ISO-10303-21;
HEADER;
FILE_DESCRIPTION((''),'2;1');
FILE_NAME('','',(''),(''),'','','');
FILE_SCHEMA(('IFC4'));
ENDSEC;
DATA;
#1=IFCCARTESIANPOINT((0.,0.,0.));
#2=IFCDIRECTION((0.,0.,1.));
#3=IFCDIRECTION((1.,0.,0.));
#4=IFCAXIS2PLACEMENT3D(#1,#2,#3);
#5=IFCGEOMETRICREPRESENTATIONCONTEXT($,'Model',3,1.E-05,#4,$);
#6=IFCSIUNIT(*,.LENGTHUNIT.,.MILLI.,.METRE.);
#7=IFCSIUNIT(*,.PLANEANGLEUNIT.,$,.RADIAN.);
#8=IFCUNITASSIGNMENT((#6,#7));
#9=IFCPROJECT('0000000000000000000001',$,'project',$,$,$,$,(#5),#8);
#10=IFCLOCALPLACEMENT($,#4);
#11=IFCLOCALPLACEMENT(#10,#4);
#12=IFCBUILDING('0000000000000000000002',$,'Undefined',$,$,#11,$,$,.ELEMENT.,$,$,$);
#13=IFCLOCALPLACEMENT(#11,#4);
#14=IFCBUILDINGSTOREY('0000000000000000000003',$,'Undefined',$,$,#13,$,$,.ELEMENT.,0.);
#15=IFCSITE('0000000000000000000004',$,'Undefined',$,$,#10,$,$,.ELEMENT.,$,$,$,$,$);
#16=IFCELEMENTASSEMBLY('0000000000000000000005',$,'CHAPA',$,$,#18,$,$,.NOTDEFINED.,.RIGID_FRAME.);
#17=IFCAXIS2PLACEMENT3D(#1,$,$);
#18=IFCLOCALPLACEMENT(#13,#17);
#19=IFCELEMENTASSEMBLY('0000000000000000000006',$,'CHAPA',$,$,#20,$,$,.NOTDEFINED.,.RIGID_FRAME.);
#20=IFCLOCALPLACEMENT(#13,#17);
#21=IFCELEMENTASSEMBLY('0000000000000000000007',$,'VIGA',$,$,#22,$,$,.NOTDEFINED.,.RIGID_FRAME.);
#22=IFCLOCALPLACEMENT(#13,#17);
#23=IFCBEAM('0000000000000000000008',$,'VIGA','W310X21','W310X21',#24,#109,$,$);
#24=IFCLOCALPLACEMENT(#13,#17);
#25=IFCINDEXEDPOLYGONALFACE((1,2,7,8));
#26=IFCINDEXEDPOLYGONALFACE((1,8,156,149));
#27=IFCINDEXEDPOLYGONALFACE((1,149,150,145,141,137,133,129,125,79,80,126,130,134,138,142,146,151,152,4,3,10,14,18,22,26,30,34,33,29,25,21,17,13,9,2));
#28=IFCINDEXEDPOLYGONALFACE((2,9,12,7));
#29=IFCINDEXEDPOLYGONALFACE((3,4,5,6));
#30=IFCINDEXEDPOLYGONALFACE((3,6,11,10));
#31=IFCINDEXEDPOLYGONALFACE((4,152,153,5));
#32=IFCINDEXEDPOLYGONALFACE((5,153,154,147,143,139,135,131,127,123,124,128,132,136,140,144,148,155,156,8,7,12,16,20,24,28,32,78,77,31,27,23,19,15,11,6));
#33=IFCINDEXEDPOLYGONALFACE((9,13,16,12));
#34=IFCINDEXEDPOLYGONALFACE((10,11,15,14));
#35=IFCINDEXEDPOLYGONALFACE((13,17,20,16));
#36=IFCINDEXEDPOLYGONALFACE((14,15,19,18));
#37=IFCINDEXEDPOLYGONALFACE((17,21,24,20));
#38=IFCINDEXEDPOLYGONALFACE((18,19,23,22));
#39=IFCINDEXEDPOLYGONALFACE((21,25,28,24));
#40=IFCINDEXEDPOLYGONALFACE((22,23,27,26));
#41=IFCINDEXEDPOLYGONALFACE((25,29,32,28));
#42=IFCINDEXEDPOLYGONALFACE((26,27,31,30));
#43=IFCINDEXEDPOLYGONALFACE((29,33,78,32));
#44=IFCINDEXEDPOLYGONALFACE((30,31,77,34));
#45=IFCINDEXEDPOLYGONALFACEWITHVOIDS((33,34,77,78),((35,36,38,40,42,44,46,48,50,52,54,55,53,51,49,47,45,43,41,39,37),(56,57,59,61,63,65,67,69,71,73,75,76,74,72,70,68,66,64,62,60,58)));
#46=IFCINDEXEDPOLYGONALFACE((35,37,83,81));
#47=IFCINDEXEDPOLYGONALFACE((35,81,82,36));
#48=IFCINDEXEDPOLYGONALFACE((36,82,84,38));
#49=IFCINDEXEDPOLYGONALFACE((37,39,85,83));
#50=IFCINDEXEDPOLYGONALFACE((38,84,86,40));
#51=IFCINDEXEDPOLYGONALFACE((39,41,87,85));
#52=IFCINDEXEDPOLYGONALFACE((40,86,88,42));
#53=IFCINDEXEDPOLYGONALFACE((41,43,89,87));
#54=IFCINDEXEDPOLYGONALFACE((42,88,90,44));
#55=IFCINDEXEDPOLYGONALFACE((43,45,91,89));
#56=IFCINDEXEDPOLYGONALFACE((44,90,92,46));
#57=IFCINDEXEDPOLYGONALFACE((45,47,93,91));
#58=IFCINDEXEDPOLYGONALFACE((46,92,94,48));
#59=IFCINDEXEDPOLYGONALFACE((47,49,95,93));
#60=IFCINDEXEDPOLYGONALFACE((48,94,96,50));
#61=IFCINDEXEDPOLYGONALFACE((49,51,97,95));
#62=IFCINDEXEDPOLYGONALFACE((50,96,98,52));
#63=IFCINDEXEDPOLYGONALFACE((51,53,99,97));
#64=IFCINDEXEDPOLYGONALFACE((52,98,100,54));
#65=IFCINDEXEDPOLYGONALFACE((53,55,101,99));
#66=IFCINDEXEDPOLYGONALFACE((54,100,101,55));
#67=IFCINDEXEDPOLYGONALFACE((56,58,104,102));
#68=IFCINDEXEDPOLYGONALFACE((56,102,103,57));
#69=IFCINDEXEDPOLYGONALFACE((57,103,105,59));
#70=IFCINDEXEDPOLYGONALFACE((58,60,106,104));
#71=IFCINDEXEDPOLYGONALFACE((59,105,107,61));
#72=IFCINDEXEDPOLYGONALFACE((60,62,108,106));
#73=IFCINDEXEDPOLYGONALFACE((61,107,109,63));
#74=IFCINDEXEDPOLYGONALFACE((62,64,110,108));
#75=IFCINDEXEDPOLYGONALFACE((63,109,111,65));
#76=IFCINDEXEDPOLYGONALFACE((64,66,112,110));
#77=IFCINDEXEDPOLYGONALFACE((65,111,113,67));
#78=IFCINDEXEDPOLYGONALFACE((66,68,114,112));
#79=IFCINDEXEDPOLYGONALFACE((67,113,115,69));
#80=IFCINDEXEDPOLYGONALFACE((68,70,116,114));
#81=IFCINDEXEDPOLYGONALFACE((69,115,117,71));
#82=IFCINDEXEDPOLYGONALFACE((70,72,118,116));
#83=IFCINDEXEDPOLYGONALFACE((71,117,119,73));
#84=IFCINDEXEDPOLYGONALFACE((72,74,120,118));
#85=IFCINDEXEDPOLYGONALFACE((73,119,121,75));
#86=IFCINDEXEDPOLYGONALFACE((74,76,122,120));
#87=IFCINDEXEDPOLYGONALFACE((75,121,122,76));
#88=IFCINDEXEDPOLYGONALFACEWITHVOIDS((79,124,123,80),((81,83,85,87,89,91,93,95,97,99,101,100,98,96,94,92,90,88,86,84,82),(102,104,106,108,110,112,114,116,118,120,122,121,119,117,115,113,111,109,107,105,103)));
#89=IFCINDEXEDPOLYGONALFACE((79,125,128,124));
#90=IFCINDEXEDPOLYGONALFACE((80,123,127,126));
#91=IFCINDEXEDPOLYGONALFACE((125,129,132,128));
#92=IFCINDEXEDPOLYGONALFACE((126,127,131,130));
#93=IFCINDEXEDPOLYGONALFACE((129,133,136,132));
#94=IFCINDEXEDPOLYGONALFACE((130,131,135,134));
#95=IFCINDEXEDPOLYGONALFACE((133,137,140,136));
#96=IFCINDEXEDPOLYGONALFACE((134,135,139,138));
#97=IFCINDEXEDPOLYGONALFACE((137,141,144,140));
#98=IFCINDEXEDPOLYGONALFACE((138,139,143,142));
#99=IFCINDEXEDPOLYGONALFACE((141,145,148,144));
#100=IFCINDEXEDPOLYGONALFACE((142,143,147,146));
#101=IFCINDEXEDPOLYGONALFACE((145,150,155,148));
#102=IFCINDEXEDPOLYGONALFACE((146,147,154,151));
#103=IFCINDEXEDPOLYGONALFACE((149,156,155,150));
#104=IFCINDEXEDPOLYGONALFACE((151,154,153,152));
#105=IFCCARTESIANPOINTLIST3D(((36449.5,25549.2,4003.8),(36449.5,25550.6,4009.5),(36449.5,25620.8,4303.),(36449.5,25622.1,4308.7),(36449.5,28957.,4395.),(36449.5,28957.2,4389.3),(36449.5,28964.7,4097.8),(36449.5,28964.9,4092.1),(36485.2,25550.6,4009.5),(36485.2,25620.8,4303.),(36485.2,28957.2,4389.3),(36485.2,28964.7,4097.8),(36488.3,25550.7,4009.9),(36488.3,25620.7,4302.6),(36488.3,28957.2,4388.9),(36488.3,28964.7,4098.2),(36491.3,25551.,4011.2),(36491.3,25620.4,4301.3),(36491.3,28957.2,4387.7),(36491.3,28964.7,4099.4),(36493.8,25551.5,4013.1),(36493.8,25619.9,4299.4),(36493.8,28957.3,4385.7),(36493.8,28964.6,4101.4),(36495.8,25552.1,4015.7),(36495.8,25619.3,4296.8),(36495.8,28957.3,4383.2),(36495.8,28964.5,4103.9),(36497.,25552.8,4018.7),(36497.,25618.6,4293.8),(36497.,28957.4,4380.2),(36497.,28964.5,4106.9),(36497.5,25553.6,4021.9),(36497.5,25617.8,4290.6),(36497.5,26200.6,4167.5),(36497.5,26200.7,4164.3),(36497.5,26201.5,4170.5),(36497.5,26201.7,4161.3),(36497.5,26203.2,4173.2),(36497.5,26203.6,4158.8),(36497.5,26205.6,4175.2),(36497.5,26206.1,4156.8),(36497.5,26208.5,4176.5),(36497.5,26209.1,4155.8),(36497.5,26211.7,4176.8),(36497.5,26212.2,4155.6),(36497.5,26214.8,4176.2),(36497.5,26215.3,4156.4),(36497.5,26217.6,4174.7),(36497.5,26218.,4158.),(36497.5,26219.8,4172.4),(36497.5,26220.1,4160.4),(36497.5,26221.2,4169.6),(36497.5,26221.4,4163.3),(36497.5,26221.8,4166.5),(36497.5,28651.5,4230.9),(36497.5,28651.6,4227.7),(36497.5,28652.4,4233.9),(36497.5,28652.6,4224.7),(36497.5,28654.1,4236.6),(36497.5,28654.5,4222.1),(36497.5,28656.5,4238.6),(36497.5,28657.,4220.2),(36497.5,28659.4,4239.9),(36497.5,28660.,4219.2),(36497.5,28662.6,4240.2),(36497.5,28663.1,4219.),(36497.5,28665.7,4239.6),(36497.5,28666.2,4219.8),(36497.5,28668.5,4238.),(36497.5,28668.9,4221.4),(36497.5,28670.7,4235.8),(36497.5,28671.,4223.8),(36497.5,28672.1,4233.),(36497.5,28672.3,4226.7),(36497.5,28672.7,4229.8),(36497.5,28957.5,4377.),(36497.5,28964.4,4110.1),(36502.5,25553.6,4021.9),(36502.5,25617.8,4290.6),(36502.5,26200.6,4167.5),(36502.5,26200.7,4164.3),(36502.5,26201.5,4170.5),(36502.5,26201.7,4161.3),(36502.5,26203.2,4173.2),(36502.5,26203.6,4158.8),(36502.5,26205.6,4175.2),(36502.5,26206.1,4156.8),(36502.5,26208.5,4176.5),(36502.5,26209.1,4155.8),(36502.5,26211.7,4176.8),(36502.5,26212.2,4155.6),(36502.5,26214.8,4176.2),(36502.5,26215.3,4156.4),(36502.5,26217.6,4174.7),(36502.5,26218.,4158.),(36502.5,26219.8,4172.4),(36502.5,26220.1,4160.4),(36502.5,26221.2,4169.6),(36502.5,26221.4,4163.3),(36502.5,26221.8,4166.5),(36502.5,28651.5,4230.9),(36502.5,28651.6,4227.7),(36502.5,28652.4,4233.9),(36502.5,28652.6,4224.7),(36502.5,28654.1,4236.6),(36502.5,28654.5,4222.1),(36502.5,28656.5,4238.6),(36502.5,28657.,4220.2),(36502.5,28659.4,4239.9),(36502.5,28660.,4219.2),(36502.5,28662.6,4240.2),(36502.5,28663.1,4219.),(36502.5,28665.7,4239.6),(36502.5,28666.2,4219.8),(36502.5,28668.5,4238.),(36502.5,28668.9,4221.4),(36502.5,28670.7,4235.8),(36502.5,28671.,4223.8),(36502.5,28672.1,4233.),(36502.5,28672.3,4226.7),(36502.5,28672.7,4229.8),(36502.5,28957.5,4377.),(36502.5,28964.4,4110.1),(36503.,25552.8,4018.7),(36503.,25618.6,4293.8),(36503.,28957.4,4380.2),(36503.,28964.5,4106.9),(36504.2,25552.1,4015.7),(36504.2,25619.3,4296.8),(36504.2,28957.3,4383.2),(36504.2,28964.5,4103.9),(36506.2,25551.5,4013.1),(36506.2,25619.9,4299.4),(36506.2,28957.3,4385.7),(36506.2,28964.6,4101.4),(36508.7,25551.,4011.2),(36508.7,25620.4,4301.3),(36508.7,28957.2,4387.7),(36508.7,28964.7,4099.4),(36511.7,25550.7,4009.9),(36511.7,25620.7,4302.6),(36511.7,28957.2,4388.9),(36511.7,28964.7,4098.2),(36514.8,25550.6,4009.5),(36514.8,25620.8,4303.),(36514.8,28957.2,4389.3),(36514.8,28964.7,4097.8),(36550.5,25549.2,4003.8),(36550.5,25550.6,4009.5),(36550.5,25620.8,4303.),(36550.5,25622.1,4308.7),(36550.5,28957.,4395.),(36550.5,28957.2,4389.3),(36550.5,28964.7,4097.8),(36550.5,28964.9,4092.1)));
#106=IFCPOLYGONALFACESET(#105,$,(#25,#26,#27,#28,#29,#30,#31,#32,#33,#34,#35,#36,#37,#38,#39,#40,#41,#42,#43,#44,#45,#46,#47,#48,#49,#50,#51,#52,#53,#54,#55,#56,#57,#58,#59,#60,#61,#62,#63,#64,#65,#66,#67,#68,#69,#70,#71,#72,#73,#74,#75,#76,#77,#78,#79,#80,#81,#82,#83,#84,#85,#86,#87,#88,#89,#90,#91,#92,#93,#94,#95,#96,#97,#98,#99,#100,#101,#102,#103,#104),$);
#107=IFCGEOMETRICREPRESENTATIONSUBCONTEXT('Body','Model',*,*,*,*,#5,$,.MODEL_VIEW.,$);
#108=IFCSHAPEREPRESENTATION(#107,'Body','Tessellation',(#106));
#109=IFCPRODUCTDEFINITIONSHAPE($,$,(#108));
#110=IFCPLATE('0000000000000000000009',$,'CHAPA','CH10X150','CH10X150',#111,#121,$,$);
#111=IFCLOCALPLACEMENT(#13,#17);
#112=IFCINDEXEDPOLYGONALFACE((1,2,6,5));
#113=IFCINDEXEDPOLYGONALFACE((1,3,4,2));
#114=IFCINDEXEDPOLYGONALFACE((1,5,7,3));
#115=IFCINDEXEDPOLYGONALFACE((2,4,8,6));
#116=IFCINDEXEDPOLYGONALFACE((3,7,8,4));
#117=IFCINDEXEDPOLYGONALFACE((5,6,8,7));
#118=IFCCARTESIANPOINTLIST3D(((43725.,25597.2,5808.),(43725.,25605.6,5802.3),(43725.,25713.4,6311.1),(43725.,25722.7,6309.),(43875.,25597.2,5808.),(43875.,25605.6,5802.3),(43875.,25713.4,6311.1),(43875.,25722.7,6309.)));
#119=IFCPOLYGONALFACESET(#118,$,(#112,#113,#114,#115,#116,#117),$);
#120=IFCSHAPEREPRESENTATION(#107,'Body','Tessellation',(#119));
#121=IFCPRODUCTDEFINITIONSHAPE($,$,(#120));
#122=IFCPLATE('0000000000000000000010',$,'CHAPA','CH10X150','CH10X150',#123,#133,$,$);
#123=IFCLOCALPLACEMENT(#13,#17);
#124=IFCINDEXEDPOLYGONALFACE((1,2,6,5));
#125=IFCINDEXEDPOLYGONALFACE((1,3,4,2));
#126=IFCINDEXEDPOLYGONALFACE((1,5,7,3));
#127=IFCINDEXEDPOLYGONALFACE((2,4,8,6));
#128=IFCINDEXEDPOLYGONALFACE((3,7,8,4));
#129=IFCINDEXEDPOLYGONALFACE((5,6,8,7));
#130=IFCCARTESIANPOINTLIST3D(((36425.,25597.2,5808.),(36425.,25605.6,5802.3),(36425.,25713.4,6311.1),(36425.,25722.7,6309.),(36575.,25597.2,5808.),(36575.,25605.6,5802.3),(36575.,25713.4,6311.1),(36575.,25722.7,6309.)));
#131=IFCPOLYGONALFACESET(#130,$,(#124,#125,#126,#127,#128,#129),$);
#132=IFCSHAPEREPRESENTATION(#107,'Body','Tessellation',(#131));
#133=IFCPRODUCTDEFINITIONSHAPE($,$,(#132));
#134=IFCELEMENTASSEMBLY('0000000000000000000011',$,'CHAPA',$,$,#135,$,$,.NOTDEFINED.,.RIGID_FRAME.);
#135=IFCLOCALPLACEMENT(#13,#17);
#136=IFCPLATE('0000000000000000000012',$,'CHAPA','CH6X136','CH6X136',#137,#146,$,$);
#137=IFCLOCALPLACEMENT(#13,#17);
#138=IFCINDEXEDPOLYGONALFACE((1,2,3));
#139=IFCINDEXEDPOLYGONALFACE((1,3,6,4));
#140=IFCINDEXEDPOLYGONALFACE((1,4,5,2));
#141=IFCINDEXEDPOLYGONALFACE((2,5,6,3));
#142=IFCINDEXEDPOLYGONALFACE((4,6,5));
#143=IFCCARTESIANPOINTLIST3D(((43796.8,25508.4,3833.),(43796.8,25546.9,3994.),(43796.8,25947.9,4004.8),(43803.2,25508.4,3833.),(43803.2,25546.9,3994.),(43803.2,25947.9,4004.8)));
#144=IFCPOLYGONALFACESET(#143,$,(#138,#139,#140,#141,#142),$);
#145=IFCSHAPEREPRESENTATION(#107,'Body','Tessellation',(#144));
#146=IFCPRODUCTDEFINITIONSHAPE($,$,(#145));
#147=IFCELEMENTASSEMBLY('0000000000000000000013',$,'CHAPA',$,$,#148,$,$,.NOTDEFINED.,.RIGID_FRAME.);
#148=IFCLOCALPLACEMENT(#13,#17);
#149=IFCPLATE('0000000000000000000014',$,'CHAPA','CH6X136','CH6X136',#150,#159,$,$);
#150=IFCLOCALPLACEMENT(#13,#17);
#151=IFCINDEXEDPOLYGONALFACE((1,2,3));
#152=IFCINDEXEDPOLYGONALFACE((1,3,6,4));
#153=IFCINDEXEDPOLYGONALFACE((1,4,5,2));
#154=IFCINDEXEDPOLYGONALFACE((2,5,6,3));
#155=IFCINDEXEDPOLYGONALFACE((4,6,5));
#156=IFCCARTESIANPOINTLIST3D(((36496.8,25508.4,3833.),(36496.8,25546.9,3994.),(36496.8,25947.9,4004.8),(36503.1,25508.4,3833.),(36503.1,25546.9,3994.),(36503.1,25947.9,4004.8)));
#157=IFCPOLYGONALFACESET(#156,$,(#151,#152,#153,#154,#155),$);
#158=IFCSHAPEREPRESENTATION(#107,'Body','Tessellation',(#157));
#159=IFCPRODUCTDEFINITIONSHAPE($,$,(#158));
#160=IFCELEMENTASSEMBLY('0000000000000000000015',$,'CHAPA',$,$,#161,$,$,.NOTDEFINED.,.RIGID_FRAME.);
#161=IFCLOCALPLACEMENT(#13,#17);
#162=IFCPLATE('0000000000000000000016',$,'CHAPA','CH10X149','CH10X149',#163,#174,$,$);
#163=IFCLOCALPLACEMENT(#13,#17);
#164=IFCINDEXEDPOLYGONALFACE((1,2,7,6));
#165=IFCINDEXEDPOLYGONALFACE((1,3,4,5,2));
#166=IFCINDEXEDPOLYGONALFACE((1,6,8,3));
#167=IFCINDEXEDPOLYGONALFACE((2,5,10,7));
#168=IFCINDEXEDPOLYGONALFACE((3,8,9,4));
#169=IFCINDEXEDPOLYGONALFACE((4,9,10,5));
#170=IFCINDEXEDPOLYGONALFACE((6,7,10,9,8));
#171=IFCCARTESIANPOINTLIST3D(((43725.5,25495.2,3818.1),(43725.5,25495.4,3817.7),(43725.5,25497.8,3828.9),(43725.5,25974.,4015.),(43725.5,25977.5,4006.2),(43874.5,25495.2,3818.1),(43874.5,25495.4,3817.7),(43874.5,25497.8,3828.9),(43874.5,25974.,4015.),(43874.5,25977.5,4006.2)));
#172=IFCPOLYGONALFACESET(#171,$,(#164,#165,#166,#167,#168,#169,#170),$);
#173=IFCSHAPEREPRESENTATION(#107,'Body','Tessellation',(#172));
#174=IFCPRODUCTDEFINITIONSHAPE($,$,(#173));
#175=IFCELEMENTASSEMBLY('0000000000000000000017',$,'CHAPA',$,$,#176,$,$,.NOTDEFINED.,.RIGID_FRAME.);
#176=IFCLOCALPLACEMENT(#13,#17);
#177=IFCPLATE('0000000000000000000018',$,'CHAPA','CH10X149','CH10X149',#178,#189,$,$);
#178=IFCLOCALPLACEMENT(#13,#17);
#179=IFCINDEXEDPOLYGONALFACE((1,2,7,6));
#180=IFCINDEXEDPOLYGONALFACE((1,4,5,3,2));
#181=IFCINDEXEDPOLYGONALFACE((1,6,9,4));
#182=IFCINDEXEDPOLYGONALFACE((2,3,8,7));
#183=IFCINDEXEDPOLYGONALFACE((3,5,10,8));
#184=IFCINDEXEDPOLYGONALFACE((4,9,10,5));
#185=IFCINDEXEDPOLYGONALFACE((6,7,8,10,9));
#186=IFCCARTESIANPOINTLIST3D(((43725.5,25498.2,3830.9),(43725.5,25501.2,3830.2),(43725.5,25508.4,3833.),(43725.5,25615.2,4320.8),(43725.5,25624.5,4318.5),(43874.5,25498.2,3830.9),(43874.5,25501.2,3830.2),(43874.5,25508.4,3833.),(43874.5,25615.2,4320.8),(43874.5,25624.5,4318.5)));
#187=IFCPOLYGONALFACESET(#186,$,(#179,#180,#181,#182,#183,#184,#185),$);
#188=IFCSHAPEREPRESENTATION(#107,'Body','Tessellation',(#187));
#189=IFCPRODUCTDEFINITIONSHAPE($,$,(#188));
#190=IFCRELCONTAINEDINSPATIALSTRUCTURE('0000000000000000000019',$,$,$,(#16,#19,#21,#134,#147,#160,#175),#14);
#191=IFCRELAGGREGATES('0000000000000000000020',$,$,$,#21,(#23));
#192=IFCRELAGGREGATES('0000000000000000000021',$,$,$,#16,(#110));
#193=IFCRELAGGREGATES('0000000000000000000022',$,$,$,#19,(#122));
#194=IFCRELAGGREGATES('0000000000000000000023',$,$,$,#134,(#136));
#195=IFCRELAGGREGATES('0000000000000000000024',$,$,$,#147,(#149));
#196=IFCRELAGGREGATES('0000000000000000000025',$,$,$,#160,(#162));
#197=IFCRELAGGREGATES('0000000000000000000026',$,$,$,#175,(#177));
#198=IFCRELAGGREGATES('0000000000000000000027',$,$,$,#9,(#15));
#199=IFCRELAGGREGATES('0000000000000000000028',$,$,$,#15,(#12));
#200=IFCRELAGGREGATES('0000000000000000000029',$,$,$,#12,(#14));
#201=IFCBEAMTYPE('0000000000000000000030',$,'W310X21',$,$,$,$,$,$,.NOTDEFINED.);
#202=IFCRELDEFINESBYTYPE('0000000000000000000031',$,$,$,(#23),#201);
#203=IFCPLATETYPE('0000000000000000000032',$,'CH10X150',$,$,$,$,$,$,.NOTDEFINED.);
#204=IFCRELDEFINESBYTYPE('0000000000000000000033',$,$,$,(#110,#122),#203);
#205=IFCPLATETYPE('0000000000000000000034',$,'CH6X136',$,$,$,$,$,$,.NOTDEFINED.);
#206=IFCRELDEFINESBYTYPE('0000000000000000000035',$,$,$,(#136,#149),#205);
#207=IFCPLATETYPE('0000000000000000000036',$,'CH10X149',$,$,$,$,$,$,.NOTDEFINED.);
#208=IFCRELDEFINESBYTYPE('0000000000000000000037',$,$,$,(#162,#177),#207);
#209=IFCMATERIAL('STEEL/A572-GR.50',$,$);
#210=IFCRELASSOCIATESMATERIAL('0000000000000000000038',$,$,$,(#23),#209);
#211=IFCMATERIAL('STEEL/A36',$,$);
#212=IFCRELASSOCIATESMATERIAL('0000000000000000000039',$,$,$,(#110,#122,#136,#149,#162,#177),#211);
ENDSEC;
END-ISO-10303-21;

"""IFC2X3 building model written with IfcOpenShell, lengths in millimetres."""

from ifc_helpers import new_model, si_unit, frame, origin_with_axes, origin_2d_with_axis, place, context, subcontext, project, spatial, polyline, circle, i_section, outline, extrude, boolean, clip, halfspace, material, type_object, element, aggregate, save


model = new_model("IFC2X3")

# Units and contexts
model_context = context("Model", 3, precision=1e-05, world=origin_with_axes())
body_context = subcontext(model_context, "Body", "Model", "MODEL_VIEW")
ifc_project = project(units=[si_unit("LENGTHUNIT", "METRE", prefix="MILLI"), si_unit("PLANEANGLEUNIT", "RADIAN")], contexts=[model_context])

# Site, building, storey
site_placement = place(None, origin_with_axes())
site = spatial("IfcSite", under=ifc_project, at=site_placement, Name="Undefined", CompositionType="ELEMENT")
building_placement = place(site_placement, origin_with_axes())
building = spatial("IfcBuilding", under=site, at=building_placement, Name="Undefined", CompositionType="ELEMENT")
storey_placement = place(building_placement, origin_with_axes())
storey = spatial("IfcBuildingStorey", under=building, at=storey_placement, Name="Undefined", CompositionType="ELEMENT", Elevation=0.0)

# Element assemblies, beam
ifc_material_1 = material(Name="STEEL/A572-GR.50")
assembly_1_placement = place(storey_placement, origin_with_axes())
assembly_1 = element("IfcElementAssembly", 1, at=assembly_1_placement, inside=storey, Name="CHAPA", AssemblyPlace="NOTDEFINED", PredefinedType="RIGID_FRAME")
assembly_2_placement = place(storey_placement, origin_with_axes())
assembly_2 = element("IfcElementAssembly", 2, at=assembly_2_placement, inside=storey, Name="CHAPA", AssemblyPlace="NOTDEFINED", PredefinedType="RIGID_FRAME")
beam_type_1 = type_object("IfcBeamType", Name="W310X21", PredefinedType="NOTDEFINED")
assembly_3_placement = place(storey_placement, origin_with_axes())
assembly_3 = element("IfcElementAssembly", 3, at=assembly_3_placement, inside=storey, Name="VIGA", AssemblyPlace="NOTDEFINED", PredefinedType="RIGID_FRAME")
beam_1_placement = place(assembly_3_placement, frame((36500.0, 25403.9, 4151.6), z_axis=(0.0, -0.025855, 0.999666), x_axis=(0.0, 0.999666, 0.025855)))
beam_1 = element("IfcBeam", 4, at=beam_1_placement, type_object=beam_type_1, material=ifc_material_1, Name="VIGA", Description="W310X21", ObjectType="W310X21", context=body_context, shape_type="CSG", body=[
    boolean("DIFFERENCE", boolean("DIFFERENCE", boolean("DIFFERENCE", extrude(i_section(OverallWidth=101.0, OverallDepth=303.0, WebThickness=5.1, FlangeThickness=5.7, FilletRadius=12.3, at=origin_2d_with_axis()), frame((3558.2, 0.0, 0.0), z_axis=(-1.0, 0.0, 0.0), x_axis=(0.0, -1.0, 0.0)), (0.0, 0.0, 1.0), 3558.2), extrude(circle(Radius=10.6, at=origin_2d_with_axis()), frame((3259.1, -100.0, -6.3), z_axis=(0.0, 1.0, 0.0), x_axis=(1.0, 0.0, 0.0)), (0.0, 0.0, 1.0), 200.0)), extrude(circle(Radius=10.6, at=origin_2d_with_axis()), frame((807.4, -100.0, -6.2), z_axis=(0.0, 1.0, 0.0), x_axis=(1.0, 0.0, 0.0)), (0.0, 0.0, 1.0), 200.0)), halfspace(frame((141.4, -50.5, -151.7), z_axis=(-0.966259, 0.0, 0.257573), x_axis=(0.0, 1.0, 0.0)), False)),
])
aggregate(assembly_3, [beam_1])

# Plates
ifc_material_2 = material(Name="STEEL/A36")
plate_type_1 = type_object("IfcPlateType", Name="CH10X150", PredefinedType="NOTDEFINED")
plate_1_placement = place(assembly_1_placement, frame((43875.0, 25718.1, 6310.1), z_axis=(0.0, 0.97433, -0.225124), x_axis=(0.0, -0.225124, -0.97433)))
plate_1 = element("IfcPlate", 5, at=plate_1_placement, type_object=plate_type_1, material=ifc_material_2, Name="CHAPA", Description="CH10X150", ObjectType="CH10X150", context=body_context, shape_type="Clipping", body=[
    clip(extrude(outline(polyline([(0.0, 0.0), (520.0, 0.0), (520.0, 150.0), (0.0, 150.0), (0.0, 0.0)])), frame((0.0, 0.0, -4.8), z_axis=(0.0, 0.0, 1.0), x_axis=(1.0, 0.0, 0.0)), (0.0, 0.0, 1.0), 9.5), halfspace(frame((516.4, -500.0, -4.7), z_axis=(0.934951, 0.0, -0.354778), x_axis=(0.354778, 0.0, 0.934951)), False)),
])
aggregate(assembly_1, [plate_1])
plate_2_placement = place(assembly_2_placement, frame((36575.0, 25718.1, 6310.1), z_axis=(0.0, 0.97433, -0.225124), x_axis=(0.0, -0.225124, -0.97433)))
plate_2 = element("IfcPlate", 6, at=plate_2_placement, type_object=plate_type_1, material=ifc_material_2, Name="CHAPA", Description="CH10X150", ObjectType="CH10X150", context=body_context, shape_type="Clipping", body=[
    clip(extrude(outline(polyline([(0.0, 0.0), (520.0, 0.0), (520.0, 150.0), (0.0, 150.0), (0.0, 0.0)])), frame((0.0, 0.0, -4.8), z_axis=(0.0, 0.0, 1.0), x_axis=(1.0, 0.0, 0.0)), (0.0, 0.0, 1.0), 9.5), halfspace(frame((516.4, -500.0, -4.7), z_axis=(0.934951, 0.0, -0.354778), x_axis=(0.354778, 0.0, 0.934951)), False)),
])
aggregate(assembly_2, [plate_2])

# Element assemblies, plates
assembly_4_placement = place(storey_placement, origin_with_axes())
assembly_4 = element("IfcElementAssembly", 7, at=assembly_4_placement, inside=storey, Name="CHAPA", AssemblyPlace="NOTDEFINED", PredefinedType="RIGID_FRAME")
plate_type_2 = type_object("IfcPlateType", Name="CH6X136", PredefinedType="NOTDEFINED")
plate_3_placement = place(assembly_4_placement, frame((43800.0, 25546.9, 3994.0), z_axis=(-1.0, 0.0, 0.0), x_axis=(0.0, 0.999636, 0.026972)))
plate_3 = element("IfcPlate", 8, at=plate_3_placement, type_object=plate_type_2, material=ifc_material_2, Name="CHAPA", Description="CH6X136", ObjectType="CH6X136", context=body_context, shape_type="SweptSolid", body=[
    extrude(outline(polyline([(0.0, 0.0), (401.1, 0.0), (-42.8, 159.9), (0.0, 0.0)])), frame((0.0, 0.0, -3.1), z_axis=(0.0, 0.0, 1.0), x_axis=(1.0, 0.0, 0.0)), (0.0, 0.0, 1.0), 6.3),
])
aggregate(assembly_4, [plate_3])
assembly_5_placement = place(storey_placement, origin_with_axes())
assembly_5 = element("IfcElementAssembly", 9, at=assembly_5_placement, inside=storey, Name="CHAPA", AssemblyPlace="NOTDEFINED", PredefinedType="RIGID_FRAME")
plate_4_placement = place(assembly_5_placement, frame((36500.0, 25546.9, 3994.0), z_axis=(-1.0, 0.0, 0.0), x_axis=(0.0, 0.999636, 0.026972)))
plate_4 = element("IfcPlate", 10, at=plate_4_placement, type_object=plate_type_2, material=ifc_material_2, Name="CHAPA", Description="CH6X136", ObjectType="CH6X136", context=body_context, shape_type="SweptSolid", body=[
    extrude(outline(polyline([(0.0, 0.0), (401.1, 0.0), (-42.8, 159.9), (0.0, 0.0)])), frame((0.0, 0.0, -3.1), z_axis=(0.0, 0.0, 1.0), x_axis=(1.0, 0.0, 0.0)), (0.0, 0.0, 1.0), 6.3),
])
aggregate(assembly_5, [plate_4])
assembly_6_placement = place(storey_placement, origin_with_axes())
assembly_6 = element("IfcElementAssembly", 11, at=assembly_6_placement, inside=storey, Name="CHAPA", AssemblyPlace="NOTDEFINED", PredefinedType="RIGID_FRAME")
plate_type_3 = type_object("IfcPlateType", Name="CH10X149", PredefinedType="NOTDEFINED")
plate_5_placement = place(assembly_6_placement, frame((43725.5, 25975.7, 4010.6), z_axis=(0.0, 0.364063, -0.931374), x_axis=(1.0, 0.0, 0.0)))
plate_5 = element("IfcPlate", 12, at=plate_5_placement, type_object=plate_type_3, material=ifc_material_2, Name="CHAPA", Description="CH10X149", ObjectType="CH10X149", context=body_context, shape_type="Clipping", body=[
    clip(extrude(outline(polyline([(0.0, 0.0), (149.0, 0.0), (149.0, 517.6), (0.0, 517.6), (0.0, 0.0)])), frame((0.0, 0.0, -4.8), z_axis=(0.0, 0.0, 1.0), x_axis=(1.0, 0.0, 0.0)), (0.0, 0.0, 1.0), 9.5), halfspace(frame((149.0, 517.9, 4.7), z_axis=(0.0, 0.821204, -0.570634), x_axis=(-1.0, 0.0, 0.0)), False)),
])
aggregate(assembly_6, [plate_5])
assembly_7_placement = place(storey_placement, origin_with_axes())
assembly_7 = element("IfcElementAssembly", 13, at=assembly_7_placement, inside=storey, Name="CHAPA", AssemblyPlace="NOTDEFINED", PredefinedType="RIGID_FRAME")
plate_6_placement = place(assembly_7_placement, frame((43725.5, 25619.9, 4319.6), z_axis=(0.0, 0.972612, -0.232434), x_axis=(1.0, 0.000007, 0.000031)))
plate_6 = element("IfcPlate", 14, at=plate_6_placement, type_object=plate_type_3, material=ifc_material_2, Name="CHAPA", Description="CH10X149", ObjectType="CH10X149", context=body_context, shape_type="Clipping", body=[
    clip(extrude(outline(polyline([(0.0, 0.0), (70.9, 0.0), (149.0, 0.0), (149.0, 503.6), (0.0, 503.6), (0.0, 0.0)])), frame((0.0, 0.0, -4.8), z_axis=(0.0, 0.0, 1.0), x_axis=(1.0, 0.0, 0.0)), (0.0, 0.0, 1.0), 9.5), halfspace(frame((70.9, 499.2, 4.7), z_axis=(-0.000026, 0.821245, 0.570575), x_axis=(-1.0, -0.000032, 0.0)), False)),
])

aggregate(assembly_7, [plate_6])

save(model, "model.ifc")
